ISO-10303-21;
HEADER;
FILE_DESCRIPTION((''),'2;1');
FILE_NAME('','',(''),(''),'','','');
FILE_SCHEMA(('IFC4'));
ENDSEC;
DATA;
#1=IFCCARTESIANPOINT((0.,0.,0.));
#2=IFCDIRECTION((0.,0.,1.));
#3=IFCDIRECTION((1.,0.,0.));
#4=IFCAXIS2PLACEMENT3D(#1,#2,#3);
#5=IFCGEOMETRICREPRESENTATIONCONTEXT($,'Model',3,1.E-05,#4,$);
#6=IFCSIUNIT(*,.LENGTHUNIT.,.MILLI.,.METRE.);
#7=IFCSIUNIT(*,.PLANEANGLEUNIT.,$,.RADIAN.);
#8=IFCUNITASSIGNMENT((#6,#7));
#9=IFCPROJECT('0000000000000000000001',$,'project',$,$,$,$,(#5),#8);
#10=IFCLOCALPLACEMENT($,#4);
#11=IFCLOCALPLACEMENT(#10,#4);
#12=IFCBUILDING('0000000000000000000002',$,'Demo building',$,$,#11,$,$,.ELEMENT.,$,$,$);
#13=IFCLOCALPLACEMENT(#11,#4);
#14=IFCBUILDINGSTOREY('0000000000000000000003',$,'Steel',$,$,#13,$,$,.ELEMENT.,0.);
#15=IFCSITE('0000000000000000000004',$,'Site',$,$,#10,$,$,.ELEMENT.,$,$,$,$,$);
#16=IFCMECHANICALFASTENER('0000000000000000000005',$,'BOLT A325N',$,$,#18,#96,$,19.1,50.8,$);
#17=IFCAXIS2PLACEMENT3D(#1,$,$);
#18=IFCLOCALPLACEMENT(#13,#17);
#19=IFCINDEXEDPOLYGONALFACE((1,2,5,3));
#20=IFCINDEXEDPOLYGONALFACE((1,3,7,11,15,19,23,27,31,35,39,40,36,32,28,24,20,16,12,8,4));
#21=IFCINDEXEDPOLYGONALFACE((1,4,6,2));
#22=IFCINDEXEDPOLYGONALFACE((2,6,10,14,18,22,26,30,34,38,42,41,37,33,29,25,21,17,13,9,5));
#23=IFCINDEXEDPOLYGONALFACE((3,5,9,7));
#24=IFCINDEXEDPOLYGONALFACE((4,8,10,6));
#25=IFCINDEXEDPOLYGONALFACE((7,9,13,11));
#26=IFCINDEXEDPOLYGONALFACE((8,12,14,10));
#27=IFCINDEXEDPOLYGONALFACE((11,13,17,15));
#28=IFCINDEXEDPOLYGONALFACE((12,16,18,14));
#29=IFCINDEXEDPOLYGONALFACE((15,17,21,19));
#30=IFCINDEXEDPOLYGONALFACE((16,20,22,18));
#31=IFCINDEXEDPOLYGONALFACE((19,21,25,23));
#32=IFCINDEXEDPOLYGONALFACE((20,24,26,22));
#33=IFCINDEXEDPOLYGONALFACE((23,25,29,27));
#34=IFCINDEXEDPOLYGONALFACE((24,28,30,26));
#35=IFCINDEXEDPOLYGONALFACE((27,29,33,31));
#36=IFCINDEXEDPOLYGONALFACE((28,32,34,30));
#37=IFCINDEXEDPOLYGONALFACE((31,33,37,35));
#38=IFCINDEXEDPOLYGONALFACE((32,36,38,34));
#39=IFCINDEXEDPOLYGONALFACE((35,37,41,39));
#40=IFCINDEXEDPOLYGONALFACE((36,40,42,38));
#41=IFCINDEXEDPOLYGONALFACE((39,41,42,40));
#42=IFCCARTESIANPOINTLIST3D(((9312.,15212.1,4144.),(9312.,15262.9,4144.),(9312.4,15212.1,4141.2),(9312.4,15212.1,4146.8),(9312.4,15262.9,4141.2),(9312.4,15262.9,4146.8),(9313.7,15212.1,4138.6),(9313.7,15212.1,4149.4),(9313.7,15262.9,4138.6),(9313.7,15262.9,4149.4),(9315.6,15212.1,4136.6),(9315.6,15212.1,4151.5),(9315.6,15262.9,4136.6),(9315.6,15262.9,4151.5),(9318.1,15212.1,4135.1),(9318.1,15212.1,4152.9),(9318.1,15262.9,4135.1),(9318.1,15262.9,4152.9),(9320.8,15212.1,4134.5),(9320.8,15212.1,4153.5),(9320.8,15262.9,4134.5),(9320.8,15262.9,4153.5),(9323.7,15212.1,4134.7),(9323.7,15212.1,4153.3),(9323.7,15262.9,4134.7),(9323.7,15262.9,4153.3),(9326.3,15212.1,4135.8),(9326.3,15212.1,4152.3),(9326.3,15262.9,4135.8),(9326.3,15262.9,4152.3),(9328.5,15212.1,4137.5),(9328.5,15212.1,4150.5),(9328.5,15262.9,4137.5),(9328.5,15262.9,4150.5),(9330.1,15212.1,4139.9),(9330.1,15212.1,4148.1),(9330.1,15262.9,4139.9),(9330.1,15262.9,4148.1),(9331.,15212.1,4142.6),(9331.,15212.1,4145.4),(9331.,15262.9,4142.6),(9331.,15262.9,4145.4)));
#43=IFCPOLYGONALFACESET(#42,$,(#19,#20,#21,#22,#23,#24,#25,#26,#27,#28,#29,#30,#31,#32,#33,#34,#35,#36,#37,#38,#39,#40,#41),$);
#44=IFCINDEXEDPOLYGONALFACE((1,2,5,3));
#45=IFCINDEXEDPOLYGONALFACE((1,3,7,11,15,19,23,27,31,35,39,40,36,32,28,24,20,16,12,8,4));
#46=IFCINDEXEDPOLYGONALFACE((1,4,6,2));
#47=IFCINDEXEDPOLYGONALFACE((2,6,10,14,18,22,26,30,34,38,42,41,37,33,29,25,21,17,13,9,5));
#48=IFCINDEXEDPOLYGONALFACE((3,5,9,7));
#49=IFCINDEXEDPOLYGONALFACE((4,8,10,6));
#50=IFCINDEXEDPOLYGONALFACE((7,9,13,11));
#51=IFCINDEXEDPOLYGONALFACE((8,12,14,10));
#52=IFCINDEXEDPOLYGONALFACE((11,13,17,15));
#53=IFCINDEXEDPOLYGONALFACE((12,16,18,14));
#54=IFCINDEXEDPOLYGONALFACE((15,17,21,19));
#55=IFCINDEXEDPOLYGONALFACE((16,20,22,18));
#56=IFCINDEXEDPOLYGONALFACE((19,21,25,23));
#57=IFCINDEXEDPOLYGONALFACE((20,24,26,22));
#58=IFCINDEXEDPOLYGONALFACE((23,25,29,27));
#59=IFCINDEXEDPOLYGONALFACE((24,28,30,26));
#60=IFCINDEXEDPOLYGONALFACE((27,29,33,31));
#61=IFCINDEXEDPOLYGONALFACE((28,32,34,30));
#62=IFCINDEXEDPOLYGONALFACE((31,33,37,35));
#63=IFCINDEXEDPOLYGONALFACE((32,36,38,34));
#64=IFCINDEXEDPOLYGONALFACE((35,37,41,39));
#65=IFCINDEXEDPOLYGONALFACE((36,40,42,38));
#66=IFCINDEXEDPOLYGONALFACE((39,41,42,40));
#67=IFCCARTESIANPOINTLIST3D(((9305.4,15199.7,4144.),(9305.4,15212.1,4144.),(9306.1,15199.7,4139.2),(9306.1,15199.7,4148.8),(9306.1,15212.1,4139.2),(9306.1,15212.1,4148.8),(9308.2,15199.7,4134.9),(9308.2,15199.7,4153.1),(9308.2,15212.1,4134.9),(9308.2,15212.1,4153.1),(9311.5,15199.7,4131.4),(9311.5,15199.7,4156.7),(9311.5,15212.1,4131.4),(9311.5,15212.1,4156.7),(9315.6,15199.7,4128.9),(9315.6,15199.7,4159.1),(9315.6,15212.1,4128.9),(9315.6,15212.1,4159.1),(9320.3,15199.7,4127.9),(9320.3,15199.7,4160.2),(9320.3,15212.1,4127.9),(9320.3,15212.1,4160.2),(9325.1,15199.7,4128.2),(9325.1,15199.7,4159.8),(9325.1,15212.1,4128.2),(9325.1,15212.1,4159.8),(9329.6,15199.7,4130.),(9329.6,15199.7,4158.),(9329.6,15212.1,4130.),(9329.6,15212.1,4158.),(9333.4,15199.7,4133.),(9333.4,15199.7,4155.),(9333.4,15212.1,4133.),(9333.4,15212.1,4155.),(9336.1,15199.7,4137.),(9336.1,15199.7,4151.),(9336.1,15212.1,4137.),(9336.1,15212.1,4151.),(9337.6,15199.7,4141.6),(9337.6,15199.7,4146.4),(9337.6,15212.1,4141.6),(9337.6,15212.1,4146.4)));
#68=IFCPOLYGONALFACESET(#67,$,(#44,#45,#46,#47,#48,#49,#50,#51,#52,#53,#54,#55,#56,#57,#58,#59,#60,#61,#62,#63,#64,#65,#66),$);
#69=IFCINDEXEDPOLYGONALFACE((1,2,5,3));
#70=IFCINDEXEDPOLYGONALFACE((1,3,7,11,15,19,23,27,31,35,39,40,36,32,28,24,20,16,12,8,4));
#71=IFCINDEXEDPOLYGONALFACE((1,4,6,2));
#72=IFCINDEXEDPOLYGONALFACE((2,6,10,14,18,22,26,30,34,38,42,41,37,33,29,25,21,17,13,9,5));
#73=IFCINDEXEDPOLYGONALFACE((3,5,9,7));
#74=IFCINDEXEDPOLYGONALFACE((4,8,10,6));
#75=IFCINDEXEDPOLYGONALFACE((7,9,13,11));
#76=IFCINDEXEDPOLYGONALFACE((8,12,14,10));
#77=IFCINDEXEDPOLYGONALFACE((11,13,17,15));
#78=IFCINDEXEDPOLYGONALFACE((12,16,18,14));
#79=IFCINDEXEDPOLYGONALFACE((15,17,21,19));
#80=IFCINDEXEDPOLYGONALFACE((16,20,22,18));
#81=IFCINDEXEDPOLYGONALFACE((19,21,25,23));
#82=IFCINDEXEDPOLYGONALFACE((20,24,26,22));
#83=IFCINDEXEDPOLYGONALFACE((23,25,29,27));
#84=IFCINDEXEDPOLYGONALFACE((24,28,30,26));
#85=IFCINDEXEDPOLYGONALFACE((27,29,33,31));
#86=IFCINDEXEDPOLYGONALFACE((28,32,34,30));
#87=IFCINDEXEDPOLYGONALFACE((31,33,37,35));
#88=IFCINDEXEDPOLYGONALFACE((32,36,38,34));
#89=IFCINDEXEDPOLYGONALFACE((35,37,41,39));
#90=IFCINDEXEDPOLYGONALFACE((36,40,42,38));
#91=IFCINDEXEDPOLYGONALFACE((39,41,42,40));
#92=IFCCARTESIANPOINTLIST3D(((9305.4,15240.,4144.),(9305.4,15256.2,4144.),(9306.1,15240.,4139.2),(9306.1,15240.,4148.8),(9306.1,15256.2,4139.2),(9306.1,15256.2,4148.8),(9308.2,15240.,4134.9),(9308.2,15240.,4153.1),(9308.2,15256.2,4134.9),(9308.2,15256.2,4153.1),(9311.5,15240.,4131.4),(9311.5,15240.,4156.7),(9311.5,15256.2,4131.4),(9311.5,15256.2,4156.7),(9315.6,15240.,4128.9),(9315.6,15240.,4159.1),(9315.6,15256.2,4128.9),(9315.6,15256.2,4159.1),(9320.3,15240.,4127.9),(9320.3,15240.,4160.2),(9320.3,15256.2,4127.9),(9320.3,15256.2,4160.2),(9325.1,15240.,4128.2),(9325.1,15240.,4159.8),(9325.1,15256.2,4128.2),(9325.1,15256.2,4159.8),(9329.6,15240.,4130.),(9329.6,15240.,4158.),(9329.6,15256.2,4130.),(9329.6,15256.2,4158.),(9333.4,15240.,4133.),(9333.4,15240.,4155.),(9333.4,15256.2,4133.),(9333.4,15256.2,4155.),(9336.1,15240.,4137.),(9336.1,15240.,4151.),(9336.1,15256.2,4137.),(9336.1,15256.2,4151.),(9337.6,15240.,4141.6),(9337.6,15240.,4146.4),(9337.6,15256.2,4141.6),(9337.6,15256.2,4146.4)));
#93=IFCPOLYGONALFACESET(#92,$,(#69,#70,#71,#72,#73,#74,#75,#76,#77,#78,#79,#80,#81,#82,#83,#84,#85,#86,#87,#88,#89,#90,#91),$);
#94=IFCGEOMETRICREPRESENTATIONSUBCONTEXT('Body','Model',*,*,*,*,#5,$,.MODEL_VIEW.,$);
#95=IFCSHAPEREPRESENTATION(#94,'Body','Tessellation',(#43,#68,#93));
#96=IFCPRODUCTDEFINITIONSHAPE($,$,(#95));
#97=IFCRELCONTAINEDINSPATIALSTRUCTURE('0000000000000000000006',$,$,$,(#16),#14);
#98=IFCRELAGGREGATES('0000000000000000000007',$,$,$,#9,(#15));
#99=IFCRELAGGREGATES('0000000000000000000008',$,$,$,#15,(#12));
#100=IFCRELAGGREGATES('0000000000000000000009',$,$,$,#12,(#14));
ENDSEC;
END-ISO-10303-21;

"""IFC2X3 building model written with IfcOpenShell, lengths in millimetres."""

from ifc_helpers import new_model, si_unit, frame, origin, origin_with_axes, origin_2d, place, context, subcontext, project, spatial, circle, extrude, element, save


model = new_model("IFC2X3")

# Units and contexts
model_context = context("Model", 3, precision=1e-05, world=origin_with_axes())
body_context = subcontext(model_context, "Body", "Model", "MODEL_VIEW")
ifc_project = project(units=[si_unit("LENGTHUNIT", "METRE", prefix="MILLI"), si_unit("PLANEANGLEUNIT", "RADIAN")], contexts=[model_context])

# Site, building, storey
site_placement = place(None, origin_with_axes())
site = spatial("IfcSite", under=ifc_project, at=site_placement, Name="Site", CompositionType="ELEMENT")
building_placement = place(site_placement, origin_with_axes())
building = spatial("IfcBuilding", under=site, at=building_placement, Name="Demo building", CompositionType="ELEMENT")
placement = place(building_placement, origin_with_axes())
storey = spatial("IfcBuildingStorey", under=building, at=placement, Name="Steel", CompositionType="ELEMENT", Elevation=0.0)

# Mechanical fastener
for number, where, z_axis, x_axis, name in (
    (1, (9321.5, 15212.1, 4144.0), (0.0, 1.0, 0.0), (-1.0, 0.0, 0.0), "BOLT A325N"),
):
    element("IfcMechanicalFastener", number, at=place(placement, frame(where, z_axis=z_axis, x_axis=x_axis)), inside=storey, Name=name, NominalDiameter=19.1, NominalLength=50.8, context=body_context, shape_type="SweptSolid", body=[
        extrude(circle(Radius=9.5, at=origin_2d()), origin(), (0.0, 0.0, 1.0), 50.8),
        extrude(circle(Radius=16.2, at=origin_2d()), frame((0.0, 0.0, -12.4)), (0.0, 0.0, 1.0), 12.4),
        extrude(circle(Radius=16.2, at=origin_2d()), frame((0.0, 0.0, 27.9)), (0.0, 0.0, 1.0), 16.2),
    ])

save(model, "model.ifc")
